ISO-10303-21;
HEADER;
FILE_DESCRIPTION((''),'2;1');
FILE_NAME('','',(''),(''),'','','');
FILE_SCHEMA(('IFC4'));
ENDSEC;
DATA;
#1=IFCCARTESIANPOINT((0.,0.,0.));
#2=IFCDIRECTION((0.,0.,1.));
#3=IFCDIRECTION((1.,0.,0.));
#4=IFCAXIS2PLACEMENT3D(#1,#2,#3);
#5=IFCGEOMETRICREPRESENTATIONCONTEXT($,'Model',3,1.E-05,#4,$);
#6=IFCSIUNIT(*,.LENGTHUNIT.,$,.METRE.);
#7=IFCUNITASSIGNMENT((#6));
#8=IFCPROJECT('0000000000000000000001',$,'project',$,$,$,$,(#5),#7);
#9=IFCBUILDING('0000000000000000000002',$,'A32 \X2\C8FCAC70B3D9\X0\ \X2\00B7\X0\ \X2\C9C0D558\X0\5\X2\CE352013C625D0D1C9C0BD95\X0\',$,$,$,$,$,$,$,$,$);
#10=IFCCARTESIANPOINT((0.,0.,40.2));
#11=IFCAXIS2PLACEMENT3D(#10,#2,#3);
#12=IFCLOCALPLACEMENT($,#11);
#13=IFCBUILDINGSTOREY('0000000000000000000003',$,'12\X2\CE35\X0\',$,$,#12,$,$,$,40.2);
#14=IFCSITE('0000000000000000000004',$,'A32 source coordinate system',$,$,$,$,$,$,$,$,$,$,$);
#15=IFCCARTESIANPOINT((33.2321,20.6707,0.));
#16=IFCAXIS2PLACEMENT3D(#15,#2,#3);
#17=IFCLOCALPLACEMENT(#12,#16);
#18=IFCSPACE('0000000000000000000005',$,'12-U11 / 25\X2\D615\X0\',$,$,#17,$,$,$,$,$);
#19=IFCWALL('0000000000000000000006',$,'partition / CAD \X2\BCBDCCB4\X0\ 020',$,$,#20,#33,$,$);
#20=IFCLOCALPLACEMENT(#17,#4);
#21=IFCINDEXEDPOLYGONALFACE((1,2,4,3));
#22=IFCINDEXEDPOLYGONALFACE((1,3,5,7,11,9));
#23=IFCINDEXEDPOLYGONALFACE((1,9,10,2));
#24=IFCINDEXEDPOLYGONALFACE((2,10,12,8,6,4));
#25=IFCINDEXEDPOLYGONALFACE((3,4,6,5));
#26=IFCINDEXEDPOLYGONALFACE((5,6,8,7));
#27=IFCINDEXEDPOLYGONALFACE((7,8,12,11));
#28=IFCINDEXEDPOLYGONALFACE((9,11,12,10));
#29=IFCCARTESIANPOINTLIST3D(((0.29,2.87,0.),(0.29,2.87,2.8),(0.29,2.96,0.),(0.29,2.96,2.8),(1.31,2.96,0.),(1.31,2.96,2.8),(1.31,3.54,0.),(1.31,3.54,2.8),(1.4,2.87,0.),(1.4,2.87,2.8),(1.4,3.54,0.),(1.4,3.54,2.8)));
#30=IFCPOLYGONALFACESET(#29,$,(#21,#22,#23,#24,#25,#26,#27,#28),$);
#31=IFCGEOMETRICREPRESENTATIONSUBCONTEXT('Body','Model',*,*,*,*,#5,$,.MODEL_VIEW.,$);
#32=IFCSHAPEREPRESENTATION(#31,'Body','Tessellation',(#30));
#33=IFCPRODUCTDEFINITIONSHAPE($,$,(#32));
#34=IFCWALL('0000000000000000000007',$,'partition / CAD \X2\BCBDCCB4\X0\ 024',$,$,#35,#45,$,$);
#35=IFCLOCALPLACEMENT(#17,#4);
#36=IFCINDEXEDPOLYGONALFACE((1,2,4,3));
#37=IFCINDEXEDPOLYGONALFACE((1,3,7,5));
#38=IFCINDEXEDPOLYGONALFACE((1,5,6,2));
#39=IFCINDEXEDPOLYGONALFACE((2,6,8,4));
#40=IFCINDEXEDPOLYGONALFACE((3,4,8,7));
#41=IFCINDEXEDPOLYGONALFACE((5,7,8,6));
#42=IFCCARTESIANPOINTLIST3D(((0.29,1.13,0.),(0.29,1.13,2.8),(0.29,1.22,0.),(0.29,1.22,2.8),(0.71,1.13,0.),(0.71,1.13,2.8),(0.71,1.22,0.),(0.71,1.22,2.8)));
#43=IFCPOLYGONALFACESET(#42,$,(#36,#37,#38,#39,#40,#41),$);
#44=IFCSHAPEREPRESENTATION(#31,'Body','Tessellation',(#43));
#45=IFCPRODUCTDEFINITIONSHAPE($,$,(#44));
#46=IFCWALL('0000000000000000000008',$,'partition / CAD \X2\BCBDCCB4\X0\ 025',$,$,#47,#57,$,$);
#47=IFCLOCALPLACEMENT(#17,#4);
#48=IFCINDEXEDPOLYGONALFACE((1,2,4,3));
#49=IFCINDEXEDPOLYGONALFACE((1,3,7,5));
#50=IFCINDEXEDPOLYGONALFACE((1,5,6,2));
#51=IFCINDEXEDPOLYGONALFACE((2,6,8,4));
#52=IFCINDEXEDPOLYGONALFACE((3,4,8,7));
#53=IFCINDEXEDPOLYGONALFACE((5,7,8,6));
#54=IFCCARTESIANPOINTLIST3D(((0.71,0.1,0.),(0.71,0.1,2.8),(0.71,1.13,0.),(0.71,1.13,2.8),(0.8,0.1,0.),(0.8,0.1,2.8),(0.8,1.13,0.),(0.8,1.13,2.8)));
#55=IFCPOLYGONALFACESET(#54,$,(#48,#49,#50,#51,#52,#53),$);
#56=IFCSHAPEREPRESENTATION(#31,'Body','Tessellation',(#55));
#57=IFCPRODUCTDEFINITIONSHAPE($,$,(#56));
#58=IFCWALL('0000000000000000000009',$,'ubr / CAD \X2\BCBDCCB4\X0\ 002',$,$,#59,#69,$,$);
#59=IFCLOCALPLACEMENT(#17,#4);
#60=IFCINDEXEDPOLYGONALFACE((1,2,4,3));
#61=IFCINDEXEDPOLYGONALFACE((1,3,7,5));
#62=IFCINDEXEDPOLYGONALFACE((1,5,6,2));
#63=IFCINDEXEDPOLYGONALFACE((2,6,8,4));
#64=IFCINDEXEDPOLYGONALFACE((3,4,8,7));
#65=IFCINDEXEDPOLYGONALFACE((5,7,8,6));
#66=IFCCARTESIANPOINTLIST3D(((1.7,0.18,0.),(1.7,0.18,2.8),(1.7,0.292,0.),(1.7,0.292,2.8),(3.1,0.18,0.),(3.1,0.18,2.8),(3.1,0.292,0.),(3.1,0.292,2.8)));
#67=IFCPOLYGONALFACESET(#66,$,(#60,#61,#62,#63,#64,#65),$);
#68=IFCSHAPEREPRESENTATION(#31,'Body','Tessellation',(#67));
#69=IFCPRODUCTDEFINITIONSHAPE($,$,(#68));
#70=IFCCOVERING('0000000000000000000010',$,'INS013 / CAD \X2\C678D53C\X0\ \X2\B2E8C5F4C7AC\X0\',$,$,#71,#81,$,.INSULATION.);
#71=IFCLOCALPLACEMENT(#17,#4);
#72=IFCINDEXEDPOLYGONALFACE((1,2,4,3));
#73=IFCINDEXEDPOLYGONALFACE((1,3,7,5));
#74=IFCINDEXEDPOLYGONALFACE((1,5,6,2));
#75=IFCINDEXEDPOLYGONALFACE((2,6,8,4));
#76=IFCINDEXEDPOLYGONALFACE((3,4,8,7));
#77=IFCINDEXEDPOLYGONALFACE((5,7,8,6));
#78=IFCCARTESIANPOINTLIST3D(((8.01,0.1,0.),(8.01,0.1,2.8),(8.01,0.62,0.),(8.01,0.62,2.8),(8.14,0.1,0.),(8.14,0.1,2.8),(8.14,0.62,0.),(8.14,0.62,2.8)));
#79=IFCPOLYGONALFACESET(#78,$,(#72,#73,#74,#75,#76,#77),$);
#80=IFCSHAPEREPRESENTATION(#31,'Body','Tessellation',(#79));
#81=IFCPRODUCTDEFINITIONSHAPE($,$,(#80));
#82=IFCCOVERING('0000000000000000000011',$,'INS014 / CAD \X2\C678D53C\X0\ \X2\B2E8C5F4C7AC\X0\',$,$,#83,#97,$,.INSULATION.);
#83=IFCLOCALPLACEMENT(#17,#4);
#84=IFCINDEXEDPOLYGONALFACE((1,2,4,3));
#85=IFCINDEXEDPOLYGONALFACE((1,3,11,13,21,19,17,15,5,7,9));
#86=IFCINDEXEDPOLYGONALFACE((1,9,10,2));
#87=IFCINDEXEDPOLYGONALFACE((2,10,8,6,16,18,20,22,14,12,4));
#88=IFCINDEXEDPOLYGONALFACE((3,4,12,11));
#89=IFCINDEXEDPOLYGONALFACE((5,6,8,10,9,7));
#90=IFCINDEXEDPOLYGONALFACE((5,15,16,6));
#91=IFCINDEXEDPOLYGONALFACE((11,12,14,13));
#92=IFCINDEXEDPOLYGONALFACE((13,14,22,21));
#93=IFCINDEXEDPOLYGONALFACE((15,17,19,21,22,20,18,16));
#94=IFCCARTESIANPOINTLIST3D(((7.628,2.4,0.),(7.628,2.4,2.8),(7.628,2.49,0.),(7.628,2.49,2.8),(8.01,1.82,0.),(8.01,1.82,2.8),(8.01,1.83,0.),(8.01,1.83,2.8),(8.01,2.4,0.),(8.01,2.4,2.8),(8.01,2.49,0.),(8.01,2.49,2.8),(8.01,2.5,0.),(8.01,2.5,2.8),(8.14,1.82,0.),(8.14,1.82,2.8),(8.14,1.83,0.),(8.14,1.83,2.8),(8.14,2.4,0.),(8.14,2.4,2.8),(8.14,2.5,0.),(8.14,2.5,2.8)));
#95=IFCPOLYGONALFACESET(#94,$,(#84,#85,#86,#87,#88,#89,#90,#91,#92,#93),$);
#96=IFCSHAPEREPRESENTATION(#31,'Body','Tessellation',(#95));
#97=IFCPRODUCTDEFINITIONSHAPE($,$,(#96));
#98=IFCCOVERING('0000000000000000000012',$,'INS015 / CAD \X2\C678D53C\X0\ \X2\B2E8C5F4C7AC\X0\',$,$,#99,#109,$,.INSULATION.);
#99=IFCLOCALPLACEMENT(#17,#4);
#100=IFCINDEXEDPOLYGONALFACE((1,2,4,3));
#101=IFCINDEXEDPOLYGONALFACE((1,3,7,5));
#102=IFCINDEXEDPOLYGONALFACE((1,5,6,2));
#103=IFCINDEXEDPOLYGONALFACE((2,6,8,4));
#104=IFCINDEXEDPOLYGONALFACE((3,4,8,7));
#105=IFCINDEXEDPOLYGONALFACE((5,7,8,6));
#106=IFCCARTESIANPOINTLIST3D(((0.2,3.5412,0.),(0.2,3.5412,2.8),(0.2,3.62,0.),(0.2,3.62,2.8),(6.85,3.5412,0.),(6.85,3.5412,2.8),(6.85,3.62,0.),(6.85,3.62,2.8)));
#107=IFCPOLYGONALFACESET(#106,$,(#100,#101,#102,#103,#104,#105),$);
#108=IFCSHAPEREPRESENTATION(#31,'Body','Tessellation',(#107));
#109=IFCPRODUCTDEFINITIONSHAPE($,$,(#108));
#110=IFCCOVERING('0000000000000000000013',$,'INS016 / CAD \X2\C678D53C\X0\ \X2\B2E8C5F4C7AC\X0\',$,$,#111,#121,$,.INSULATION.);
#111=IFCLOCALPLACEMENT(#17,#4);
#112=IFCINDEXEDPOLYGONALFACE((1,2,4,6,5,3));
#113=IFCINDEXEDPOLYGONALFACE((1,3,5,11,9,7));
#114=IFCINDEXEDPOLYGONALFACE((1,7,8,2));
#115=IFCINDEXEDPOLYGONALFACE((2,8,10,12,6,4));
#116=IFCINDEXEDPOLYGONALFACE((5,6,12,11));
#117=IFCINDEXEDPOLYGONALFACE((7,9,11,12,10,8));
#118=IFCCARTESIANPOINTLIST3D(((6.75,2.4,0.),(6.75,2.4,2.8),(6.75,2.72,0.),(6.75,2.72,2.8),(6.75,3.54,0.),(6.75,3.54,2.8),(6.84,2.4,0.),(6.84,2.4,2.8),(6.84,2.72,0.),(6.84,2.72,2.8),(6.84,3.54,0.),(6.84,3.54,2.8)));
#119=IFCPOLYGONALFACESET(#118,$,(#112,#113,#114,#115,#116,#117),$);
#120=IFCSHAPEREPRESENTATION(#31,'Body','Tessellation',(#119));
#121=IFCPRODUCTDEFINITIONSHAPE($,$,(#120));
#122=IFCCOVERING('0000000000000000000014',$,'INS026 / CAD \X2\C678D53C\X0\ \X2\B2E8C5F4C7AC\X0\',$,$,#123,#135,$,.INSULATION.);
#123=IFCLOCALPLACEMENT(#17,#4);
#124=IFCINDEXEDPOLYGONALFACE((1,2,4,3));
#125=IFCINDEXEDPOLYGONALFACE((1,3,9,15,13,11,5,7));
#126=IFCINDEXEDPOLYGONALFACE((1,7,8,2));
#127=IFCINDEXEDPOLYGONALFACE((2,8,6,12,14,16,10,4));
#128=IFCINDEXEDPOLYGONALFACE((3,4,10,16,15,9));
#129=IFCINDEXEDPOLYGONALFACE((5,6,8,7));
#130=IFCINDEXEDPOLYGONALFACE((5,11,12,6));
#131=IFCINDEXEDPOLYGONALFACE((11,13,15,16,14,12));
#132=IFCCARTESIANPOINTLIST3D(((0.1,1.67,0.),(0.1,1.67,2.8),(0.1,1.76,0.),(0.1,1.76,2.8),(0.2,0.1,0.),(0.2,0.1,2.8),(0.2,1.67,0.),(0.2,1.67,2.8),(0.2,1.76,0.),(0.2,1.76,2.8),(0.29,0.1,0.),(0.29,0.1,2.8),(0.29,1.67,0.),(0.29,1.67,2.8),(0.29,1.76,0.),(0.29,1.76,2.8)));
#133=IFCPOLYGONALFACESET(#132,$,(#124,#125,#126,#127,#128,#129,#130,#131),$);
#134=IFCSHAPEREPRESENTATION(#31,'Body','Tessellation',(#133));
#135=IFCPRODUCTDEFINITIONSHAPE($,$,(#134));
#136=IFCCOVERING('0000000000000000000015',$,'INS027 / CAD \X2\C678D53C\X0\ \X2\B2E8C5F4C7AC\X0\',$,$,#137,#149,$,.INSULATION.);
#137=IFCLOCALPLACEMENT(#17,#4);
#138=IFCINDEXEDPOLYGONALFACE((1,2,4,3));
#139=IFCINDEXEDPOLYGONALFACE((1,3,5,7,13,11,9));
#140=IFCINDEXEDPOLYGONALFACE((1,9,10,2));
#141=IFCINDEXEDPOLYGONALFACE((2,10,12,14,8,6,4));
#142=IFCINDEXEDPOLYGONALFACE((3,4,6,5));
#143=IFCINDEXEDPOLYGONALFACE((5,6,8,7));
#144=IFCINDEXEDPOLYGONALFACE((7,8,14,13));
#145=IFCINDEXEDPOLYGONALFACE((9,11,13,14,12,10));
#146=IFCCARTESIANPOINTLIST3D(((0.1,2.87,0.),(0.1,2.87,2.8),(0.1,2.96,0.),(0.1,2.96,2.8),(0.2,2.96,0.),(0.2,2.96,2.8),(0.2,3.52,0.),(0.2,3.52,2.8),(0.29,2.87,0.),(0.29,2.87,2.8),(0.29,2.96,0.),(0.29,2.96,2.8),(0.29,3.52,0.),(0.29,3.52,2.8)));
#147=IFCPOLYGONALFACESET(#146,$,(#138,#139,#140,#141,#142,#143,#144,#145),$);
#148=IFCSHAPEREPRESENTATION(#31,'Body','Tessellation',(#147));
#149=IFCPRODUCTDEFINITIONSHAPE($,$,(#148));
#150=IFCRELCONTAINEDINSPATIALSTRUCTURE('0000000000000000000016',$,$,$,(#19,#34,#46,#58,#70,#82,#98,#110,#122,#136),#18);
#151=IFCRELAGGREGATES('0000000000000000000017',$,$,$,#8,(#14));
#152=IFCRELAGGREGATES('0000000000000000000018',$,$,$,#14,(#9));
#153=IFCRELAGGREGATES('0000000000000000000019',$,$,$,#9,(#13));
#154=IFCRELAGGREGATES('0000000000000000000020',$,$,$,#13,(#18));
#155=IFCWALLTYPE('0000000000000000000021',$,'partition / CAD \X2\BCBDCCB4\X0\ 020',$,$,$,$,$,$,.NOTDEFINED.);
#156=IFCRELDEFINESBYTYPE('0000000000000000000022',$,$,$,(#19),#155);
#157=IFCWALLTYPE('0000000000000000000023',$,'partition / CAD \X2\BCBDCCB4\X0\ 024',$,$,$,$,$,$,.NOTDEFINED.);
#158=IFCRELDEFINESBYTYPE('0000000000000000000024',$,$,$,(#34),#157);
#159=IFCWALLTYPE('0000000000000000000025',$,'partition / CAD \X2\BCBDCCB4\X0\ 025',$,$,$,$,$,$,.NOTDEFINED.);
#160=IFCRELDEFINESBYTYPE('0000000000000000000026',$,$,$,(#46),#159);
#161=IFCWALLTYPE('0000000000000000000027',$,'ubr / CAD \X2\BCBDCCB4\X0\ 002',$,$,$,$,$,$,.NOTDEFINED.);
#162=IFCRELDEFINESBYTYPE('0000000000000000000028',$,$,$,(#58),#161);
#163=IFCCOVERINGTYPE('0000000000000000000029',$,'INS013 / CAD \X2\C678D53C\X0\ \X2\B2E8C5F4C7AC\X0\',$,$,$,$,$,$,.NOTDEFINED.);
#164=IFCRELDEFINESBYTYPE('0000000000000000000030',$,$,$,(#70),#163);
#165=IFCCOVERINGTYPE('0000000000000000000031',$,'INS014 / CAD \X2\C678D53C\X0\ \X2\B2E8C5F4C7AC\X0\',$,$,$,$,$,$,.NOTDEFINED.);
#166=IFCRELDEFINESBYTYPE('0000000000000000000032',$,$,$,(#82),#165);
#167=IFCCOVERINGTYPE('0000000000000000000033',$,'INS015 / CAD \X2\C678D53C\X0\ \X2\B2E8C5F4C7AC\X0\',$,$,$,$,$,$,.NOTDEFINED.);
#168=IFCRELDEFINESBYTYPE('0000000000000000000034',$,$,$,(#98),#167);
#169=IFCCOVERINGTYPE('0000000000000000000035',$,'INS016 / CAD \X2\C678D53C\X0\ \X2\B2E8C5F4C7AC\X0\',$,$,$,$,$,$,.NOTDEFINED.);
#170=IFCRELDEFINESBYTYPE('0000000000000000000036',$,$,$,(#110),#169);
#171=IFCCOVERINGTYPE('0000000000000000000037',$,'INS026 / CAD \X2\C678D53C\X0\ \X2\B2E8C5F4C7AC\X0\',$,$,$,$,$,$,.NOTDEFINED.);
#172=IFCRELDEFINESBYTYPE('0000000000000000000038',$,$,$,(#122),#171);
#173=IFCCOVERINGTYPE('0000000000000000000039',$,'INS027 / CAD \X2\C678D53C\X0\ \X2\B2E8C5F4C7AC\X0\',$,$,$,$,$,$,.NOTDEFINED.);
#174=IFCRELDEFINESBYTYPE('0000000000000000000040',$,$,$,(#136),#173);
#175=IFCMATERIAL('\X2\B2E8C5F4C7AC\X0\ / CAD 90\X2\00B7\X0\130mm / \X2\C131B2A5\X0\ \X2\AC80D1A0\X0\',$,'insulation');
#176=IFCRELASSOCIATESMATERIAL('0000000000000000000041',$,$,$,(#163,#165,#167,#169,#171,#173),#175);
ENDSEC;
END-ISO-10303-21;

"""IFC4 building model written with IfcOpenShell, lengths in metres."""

from ifc_helpers import new_model, si_unit, frame, origin, origin_with_axes, place, context, subcontext, project, spatial, polyline, outline, extrude, source, transform, mapped, material, type_object, type_shapes, element, save


model = new_model("IFC4")

# Units and contexts
model_context = context("Model", 3, precision=1e-05, world=origin_with_axes())
body_context = subcontext(model_context, "Body", "Model", "MODEL_VIEW")
ifc_project = project(units=[si_unit("LENGTHUNIT", "METRE")], contexts=[model_context])

# Site, building, storey, space
storey_placement = place(None, frame((0.0, 0.0, 40.2), z_axis=(0.0, 0.0, 1.0), x_axis=(1.0, 0.0, 0.0)))
space_placement = place(storey_placement, frame((33.2321, 20.6707, 0.0), z_axis=(0.0, 0.0, 1.0), x_axis=(1.0, 0.0, 0.0)))
site = spatial("IfcSite", under=ifc_project, Name="A32 source coordinate system")
building = spatial("IfcBuilding", under=site, Name="A32 주거동 · 지하5층–옥탑지붕")
storey = spatial("IfcBuildingStorey", under=building, at=storey_placement, Name="12층", Elevation=40.2)
space = spatial("IfcSpace", under=storey, at=space_placement, Name="12-U11 / 25형")

# Walls
wall_type_1 = type_object("IfcWallType", Name="partition / CAD 벽체 020", PredefinedType="NOTDEFINED")
shared_shape_1 = source(origin(), body_context, "Body", "SweptSolid", [
    extrude(outline(polyline([(0.29, 2.87), (0.29, 2.96), (1.31, 2.96), (1.31, 3.54), (1.4, 3.54), (1.4, 2.87), (0.29, 2.87)])), origin(), (0.0, 0.0, 1.0), 2.8),
])
type_shapes(wall_type_1, [shared_shape_1])
wall_1_placement = place(space_placement, origin_with_axes())
element("IfcWall", 1, at=wall_1_placement, inside=space, type_object=wall_type_1, Name="partition / CAD 벽체 020", context=body_context, shape_type="MappedRepresentation", body=[
    mapped(shared_shape_1, transform((0.0, 0.0, 0.0), scale=1.0)),
])
wall_type_2 = type_object("IfcWallType", Name="partition / CAD 벽체 024", PredefinedType="NOTDEFINED")
shared_shape_2 = source(origin(), body_context, "Body", "SweptSolid", [
    extrude(outline(polyline([(0.71, 1.13), (0.29, 1.13), (0.29, 1.22), (0.71, 1.22), (0.71, 1.13)])), origin(), (0.0, 0.0, 1.0), 2.8),
])
type_shapes(wall_type_2, [shared_shape_2])
wall_2_placement = place(space_placement, origin_with_axes())
element("IfcWall", 2, at=wall_2_placement, inside=space, type_object=wall_type_2, Name="partition / CAD 벽체 024", context=body_context, shape_type="MappedRepresentation", body=[
    mapped(shared_shape_2, transform((0.0, 0.0, 0.0), scale=1.0)),
])
wall_type_3 = type_object("IfcWallType", Name="partition / CAD 벽체 025", PredefinedType="NOTDEFINED")
shared_shape_3 = source(origin(), body_context, "Body", "SweptSolid", [
    extrude(outline(polyline([(0.71, 1.13), (0.8, 1.13), (0.8, 0.1), (0.71, 0.1), (0.71, 1.13)])), origin(), (0.0, 0.0, 1.0), 2.8),
])
type_shapes(wall_type_3, [shared_shape_3])
wall_3_placement = place(space_placement, origin_with_axes())
element("IfcWall", 3, at=wall_3_placement, inside=space, type_object=wall_type_3, Name="partition / CAD 벽체 025", context=body_context, shape_type="MappedRepresentation", body=[
    mapped(shared_shape_3, transform((0.0, 0.0, 0.0), scale=1.0)),
])
wall_type_4 = type_object("IfcWallType", Name="ubr / CAD 벽체 002", PredefinedType="NOTDEFINED")
shared_shape_4 = source(origin(), body_context, "Body", "SweptSolid", [
    extrude(outline(polyline([(3.1, 0.292), (3.1, 0.18), (1.7, 0.18), (1.7, 0.292), (3.1, 0.292)])), origin(), (0.0, 0.0, 1.0), 2.8),
])
type_shapes(wall_type_4, [shared_shape_4])
wall_4_placement = place(space_placement, origin_with_axes())
element("IfcWall", 4, at=wall_4_placement, inside=space, type_object=wall_type_4, Name="ubr / CAD 벽체 002", context=body_context, shape_type="MappedRepresentation", body=[
    mapped(shared_shape_4, transform((0.0, 0.0, 0.0), scale=1.0)),
])

# Coverings
ifc_material = material(Name="단열재 / CAD 90·130mm / 성능 검토", Category="insulation")
covering_type_1 = type_object("IfcCoveringType", Name="INS013 / CAD 외피 단열재", PredefinedType="NOTDEFINED", material=ifc_material)
shared_shape_5 = source(origin(), body_context, "Body", "SweptSolid", [
    extrude(outline(polyline([(8.14, 0.1), (8.01, 0.1), (8.01, 0.62), (8.14, 0.62), (8.14, 0.1)])), origin(), (0.0, 0.0, 1.0), 2.8),
])
type_shapes(covering_type_1, [shared_shape_5])
covering_1_placement = place(space_placement, origin_with_axes())
element("IfcCovering", 5, at=covering_1_placement, inside=space, type_object=covering_type_1, Name="INS013 / CAD 외피 단열재", PredefinedType="INSULATION", context=body_context, shape_type="MappedRepresentation", body=[
    mapped(shared_shape_5, transform((0.0, 0.0, 0.0), scale=1.0)),
])
covering_type_2 = type_object("IfcCoveringType", Name="INS014 / CAD 외피 단열재", PredefinedType="NOTDEFINED", material=ifc_material)
shared_shape_6 = source(origin(), body_context, "Body", "SweptSolid", [
    extrude(outline(polyline([(8.14, 2.5), (8.14, 2.4), (8.14, 1.83), (8.14, 1.82), (8.01, 1.82), (8.01, 1.83), (8.01, 2.4), (7.628, 2.4), (7.628, 2.49), (8.01, 2.49), (8.01, 2.5), (8.14, 2.5)])), origin(), (0.0, 0.0, 1.0), 2.8),
])
type_shapes(covering_type_2, [shared_shape_6])
covering_2_placement = place(space_placement, origin_with_axes())
element("IfcCovering", 6, at=covering_2_placement, inside=space, type_object=covering_type_2, Name="INS014 / CAD 외피 단열재", PredefinedType="INSULATION", context=body_context, shape_type="MappedRepresentation", body=[
    mapped(shared_shape_6, transform((0.0, 0.0, 0.0), scale=1.0)),
])
covering_type_3 = type_object("IfcCoveringType", Name="INS015 / CAD 외피 단열재", PredefinedType="NOTDEFINED", material=ifc_material)
shared_shape_7 = source(origin(), body_context, "Body", "SweptSolid", [
    extrude(outline(polyline([(0.2, 3.5412), (0.2, 3.62), (6.85, 3.62), (6.85, 3.5412), (0.2, 3.5412)])), origin(), (0.0, 0.0, 1.0), 2.8),
])
type_shapes(covering_type_3, [shared_shape_7])
covering_3_placement = place(space_placement, origin_with_axes())
element("IfcCovering", 7, at=covering_3_placement, inside=space, type_object=covering_type_3, Name="INS015 / CAD 외피 단열재", PredefinedType="INSULATION", context=body_context, shape_type="MappedRepresentation", body=[
    mapped(shared_shape_7, transform((0.0, 0.0, 0.0), scale=1.0)),
])
covering_type_4 = type_object("IfcCoveringType", Name="INS016 / CAD 외피 단열재", PredefinedType="NOTDEFINED", material=ifc_material)
shared_shape_8 = source(origin(), body_context, "Body", "SweptSolid", [
    extrude(outline(polyline([(6.84, 2.72), (6.84, 2.4), (6.75, 2.4), (6.75, 2.72), (6.75, 3.54), (6.84, 3.54), (6.84, 2.72)])), origin(), (0.0, 0.0, 1.0), 2.8),
])
type_shapes(covering_type_4, [shared_shape_8])
covering_4_placement = place(space_placement, origin_with_axes())
element("IfcCovering", 8, at=covering_4_placement, inside=space, type_object=covering_type_4, Name="INS016 / CAD 외피 단열재", PredefinedType="INSULATION", context=body_context, shape_type="MappedRepresentation", body=[
    mapped(shared_shape_8, transform((0.0, 0.0, 0.0), scale=1.0)),
])
covering_type_5 = type_object("IfcCoveringType", Name="INS026 / CAD 외피 단열재", PredefinedType="NOTDEFINED", material=ifc_material)
shared_shape_9 = source(origin(), body_context, "Body", "SweptSolid", [
    extrude(outline(polyline([(0.2, 1.76), (0.29, 1.76), (0.29, 1.67), (0.29, 0.1), (0.2, 0.1), (0.2, 1.67), (0.1, 1.67), (0.1, 1.76), (0.2, 1.76)])), origin(), (0.0, 0.0, 1.0), 2.8),
])
type_shapes(covering_type_5, [shared_shape_9])
covering_5_placement = place(space_placement, origin_with_axes())
element("IfcCovering", 9, at=covering_5_placement, inside=space, type_object=covering_type_5, Name="INS026 / CAD 외피 단열재", PredefinedType="INSULATION", context=body_context, shape_type="MappedRepresentation", body=[
    mapped(shared_shape_9, transform((0.0, 0.0, 0.0), scale=1.0)),
])
covering_type_6 = type_object("IfcCoveringType", Name="INS027 / CAD 외피 단열재", PredefinedType="NOTDEFINED", material=ifc_material)
shared_shape_10 = source(origin(), body_context, "Body", "SweptSolid", [
    extrude(outline(polyline([(0.2, 3.52), (0.29, 3.52), (0.29, 2.96), (0.29, 2.87), (0.1, 2.87), (0.1, 2.96), (0.2, 2.96), (0.2, 3.52)])), origin(), (0.0, 0.0, 1.0), 2.8),
])
type_shapes(covering_type_6, [shared_shape_10])
covering_6_placement = place(space_placement, origin_with_axes())
element("IfcCovering", 10, at=covering_6_placement, inside=space, type_object=covering_type_6, Name="INS027 / CAD 외피 단열재", PredefinedType="INSULATION", context=body_context, shape_type="MappedRepresentation", body=[
    mapped(shared_shape_10, transform((0.0, 0.0, 0.0), scale=1.0)),
])

save(model, "model.ifc")
